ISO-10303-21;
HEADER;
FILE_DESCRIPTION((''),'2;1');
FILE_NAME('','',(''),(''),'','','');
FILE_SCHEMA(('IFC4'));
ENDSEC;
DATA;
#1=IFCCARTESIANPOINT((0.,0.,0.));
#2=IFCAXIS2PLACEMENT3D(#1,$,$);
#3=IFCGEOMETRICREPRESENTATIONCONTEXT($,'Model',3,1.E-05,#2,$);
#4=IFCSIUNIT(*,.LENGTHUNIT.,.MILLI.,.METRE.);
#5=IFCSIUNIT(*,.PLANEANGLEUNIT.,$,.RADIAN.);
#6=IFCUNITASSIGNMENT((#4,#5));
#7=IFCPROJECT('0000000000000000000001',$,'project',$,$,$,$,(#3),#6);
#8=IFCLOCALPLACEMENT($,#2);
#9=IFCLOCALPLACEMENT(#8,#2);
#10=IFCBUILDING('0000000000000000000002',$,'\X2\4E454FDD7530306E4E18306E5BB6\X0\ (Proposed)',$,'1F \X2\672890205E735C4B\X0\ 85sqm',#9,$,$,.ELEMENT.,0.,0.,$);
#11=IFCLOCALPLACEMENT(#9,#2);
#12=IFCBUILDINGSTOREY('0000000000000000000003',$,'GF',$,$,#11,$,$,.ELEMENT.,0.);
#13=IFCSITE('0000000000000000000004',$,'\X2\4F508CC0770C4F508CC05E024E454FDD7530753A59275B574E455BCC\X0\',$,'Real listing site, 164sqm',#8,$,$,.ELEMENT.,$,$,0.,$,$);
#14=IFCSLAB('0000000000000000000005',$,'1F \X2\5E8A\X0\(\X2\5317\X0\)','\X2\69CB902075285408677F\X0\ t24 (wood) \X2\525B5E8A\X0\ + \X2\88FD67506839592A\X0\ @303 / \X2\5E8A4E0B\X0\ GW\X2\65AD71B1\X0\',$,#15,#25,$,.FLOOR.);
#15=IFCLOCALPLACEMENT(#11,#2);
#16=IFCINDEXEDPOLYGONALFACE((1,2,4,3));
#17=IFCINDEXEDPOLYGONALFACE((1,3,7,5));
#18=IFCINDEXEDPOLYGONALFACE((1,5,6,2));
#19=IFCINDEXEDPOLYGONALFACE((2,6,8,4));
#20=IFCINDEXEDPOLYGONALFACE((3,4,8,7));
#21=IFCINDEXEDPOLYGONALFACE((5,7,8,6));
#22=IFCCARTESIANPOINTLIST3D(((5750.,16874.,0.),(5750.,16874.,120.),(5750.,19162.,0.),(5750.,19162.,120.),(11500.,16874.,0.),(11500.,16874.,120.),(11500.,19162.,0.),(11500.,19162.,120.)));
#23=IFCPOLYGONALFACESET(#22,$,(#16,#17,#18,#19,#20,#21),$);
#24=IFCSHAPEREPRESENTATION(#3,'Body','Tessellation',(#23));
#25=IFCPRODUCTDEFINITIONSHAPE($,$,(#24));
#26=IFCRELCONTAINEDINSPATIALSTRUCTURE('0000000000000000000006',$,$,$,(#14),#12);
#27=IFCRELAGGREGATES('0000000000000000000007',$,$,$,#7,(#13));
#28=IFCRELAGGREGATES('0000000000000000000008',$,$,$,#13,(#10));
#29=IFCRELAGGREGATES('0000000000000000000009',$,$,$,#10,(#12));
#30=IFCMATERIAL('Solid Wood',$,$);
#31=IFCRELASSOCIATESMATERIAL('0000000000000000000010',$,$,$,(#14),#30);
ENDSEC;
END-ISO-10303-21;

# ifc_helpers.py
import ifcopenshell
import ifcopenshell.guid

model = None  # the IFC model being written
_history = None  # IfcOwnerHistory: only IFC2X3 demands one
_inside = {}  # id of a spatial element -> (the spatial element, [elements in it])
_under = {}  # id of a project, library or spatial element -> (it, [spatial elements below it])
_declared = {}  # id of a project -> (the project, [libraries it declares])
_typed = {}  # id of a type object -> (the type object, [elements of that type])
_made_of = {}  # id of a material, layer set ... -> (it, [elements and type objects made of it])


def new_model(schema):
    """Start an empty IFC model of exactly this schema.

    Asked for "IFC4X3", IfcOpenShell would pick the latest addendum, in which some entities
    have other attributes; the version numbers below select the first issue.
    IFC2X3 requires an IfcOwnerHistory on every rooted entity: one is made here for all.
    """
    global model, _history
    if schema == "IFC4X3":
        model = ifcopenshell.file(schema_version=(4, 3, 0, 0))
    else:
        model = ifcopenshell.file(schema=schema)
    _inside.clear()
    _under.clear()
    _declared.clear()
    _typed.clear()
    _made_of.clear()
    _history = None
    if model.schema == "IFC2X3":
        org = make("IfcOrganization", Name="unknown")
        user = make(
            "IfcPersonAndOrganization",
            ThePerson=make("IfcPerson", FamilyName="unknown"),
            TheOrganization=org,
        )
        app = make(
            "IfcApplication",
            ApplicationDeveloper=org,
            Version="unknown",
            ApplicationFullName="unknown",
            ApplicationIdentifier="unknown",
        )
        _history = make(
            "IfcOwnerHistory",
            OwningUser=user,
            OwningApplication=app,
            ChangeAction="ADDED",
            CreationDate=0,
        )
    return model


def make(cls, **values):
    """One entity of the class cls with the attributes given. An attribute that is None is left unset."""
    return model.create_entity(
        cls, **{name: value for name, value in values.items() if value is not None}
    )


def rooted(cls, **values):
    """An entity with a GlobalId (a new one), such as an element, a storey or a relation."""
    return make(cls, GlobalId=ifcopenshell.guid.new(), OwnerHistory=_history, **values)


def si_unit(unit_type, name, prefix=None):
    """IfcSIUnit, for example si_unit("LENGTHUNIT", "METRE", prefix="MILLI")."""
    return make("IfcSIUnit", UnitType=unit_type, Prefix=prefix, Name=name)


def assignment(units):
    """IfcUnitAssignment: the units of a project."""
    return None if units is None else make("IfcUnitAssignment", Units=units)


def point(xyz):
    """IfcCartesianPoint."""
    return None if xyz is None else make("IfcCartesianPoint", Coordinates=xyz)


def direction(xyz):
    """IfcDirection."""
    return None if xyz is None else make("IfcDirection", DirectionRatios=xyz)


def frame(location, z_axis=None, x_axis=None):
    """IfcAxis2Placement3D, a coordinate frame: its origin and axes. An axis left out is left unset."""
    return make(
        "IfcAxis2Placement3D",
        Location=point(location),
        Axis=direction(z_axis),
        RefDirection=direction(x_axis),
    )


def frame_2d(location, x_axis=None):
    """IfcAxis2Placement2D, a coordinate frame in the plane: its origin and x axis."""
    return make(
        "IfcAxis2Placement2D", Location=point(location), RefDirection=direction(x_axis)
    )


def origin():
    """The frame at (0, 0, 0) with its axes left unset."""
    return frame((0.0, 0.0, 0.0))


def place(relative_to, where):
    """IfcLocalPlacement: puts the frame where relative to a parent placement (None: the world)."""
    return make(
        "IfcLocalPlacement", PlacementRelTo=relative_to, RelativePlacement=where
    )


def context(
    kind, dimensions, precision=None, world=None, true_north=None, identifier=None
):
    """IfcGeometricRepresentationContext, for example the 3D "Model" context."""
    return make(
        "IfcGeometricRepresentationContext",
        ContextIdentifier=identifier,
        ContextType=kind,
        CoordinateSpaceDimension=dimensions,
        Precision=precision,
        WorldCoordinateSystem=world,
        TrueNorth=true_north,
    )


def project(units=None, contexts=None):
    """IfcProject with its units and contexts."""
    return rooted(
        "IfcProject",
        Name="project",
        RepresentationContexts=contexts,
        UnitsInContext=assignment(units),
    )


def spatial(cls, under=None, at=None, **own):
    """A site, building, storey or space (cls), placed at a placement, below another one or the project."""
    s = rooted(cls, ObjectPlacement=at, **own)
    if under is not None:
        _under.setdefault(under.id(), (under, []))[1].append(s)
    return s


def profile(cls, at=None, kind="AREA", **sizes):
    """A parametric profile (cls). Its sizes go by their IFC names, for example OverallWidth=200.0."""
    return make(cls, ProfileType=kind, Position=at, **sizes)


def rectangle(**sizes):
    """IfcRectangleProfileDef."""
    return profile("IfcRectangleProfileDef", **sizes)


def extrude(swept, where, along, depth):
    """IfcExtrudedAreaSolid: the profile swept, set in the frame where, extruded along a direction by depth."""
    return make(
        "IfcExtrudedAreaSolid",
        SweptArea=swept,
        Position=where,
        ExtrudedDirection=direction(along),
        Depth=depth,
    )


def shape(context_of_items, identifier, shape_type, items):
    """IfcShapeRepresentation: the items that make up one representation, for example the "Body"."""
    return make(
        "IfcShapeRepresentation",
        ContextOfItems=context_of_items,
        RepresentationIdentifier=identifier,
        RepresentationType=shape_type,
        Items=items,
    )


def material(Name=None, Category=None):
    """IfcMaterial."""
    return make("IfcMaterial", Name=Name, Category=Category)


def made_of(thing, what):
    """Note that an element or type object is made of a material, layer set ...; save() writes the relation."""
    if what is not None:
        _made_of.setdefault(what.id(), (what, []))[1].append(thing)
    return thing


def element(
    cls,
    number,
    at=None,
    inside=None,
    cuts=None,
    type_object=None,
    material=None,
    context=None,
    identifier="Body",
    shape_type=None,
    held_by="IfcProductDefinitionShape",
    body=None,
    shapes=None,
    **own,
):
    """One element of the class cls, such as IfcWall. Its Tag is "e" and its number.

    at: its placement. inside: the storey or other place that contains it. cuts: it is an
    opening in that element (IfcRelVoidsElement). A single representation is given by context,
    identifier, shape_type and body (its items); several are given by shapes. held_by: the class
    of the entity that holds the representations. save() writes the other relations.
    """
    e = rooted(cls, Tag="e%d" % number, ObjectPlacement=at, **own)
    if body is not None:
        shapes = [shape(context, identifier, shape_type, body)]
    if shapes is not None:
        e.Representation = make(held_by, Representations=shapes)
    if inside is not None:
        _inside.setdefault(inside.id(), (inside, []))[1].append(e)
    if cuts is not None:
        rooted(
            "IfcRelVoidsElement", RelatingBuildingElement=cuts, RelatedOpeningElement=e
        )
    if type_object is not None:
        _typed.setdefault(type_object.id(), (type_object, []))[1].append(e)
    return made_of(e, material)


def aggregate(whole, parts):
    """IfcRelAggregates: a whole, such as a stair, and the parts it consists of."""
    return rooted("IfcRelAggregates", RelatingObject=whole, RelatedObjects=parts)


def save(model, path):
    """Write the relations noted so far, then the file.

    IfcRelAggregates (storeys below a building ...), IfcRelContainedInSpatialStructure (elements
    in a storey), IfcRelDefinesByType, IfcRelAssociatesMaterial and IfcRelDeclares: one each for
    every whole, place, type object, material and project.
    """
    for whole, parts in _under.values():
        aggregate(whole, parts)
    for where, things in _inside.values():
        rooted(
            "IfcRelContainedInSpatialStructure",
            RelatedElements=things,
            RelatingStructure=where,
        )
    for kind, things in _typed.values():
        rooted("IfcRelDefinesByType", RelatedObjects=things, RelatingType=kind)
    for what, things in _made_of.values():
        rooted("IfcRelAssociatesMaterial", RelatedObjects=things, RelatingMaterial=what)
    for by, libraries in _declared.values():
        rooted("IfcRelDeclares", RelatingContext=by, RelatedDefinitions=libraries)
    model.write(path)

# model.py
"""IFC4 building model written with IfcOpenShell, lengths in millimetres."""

from ifc_helpers import new_model, si_unit, frame, frame_2d, origin, place, context, project, spatial, rectangle, extrude, material, element, save


model = new_model("IFC4")

# Units and contexts
model_context = context("Model", 3, precision=1e-05, world=origin())
ifc_project = project(units=[si_unit("LENGTHUNIT", "METRE", prefix="MILLI"), si_unit("PLANEANGLEUNIT", "RADIAN")], contexts=[model_context])

# Site, building, storey
site_placement = place(None, origin())
site = spatial("IfcSite", under=ifc_project, at=site_placement, Name="佐賀県佐賀市久保田町大字久富", ObjectType="Real listing site, 164sqm", CompositionType="ELEMENT", RefElevation=0.0)
building_placement = place(site_placement, origin())
building = spatial("IfcBuilding", under=site, at=building_placement, Name="久保田の丘の家 (Proposed)", ObjectType="1F 木造平屋 85sqm", CompositionType="ELEMENT", ElevationOfRefHeight=0.0, ElevationOfTerrain=0.0)
storey_placement = place(building_placement, origin())
storey = spatial("IfcBuildingStorey", under=building, at=storey_placement, Name="GF", CompositionType="ELEMENT", Elevation=0.0)

# Slab
ifc_material_1 = material(Name="Solid Wood")
slab_1_placement = place(storey_placement, frame((2875.0, 8437.0, 0.0)))
element("IfcSlab", 1, at=slab_1_placement, inside=storey, material=ifc_material_1, Name="1F 床(北)", Description="構造用合板 t24 (wood) 剛床 + 製材根太 @303 / 床下 GW断熱", PredefinedType="FLOOR", context=model_context, shape_type="SweptSolid", body=[
    extrude(rectangle(XDim=5750.0, YDim=2288.0, at=frame_2d((2875.0, 1144.0))), frame((2875.0, 8437.0, 0.0)), (0.0, 0.0, 1.0), 120.0),
])

save(model, "model.ifc")
